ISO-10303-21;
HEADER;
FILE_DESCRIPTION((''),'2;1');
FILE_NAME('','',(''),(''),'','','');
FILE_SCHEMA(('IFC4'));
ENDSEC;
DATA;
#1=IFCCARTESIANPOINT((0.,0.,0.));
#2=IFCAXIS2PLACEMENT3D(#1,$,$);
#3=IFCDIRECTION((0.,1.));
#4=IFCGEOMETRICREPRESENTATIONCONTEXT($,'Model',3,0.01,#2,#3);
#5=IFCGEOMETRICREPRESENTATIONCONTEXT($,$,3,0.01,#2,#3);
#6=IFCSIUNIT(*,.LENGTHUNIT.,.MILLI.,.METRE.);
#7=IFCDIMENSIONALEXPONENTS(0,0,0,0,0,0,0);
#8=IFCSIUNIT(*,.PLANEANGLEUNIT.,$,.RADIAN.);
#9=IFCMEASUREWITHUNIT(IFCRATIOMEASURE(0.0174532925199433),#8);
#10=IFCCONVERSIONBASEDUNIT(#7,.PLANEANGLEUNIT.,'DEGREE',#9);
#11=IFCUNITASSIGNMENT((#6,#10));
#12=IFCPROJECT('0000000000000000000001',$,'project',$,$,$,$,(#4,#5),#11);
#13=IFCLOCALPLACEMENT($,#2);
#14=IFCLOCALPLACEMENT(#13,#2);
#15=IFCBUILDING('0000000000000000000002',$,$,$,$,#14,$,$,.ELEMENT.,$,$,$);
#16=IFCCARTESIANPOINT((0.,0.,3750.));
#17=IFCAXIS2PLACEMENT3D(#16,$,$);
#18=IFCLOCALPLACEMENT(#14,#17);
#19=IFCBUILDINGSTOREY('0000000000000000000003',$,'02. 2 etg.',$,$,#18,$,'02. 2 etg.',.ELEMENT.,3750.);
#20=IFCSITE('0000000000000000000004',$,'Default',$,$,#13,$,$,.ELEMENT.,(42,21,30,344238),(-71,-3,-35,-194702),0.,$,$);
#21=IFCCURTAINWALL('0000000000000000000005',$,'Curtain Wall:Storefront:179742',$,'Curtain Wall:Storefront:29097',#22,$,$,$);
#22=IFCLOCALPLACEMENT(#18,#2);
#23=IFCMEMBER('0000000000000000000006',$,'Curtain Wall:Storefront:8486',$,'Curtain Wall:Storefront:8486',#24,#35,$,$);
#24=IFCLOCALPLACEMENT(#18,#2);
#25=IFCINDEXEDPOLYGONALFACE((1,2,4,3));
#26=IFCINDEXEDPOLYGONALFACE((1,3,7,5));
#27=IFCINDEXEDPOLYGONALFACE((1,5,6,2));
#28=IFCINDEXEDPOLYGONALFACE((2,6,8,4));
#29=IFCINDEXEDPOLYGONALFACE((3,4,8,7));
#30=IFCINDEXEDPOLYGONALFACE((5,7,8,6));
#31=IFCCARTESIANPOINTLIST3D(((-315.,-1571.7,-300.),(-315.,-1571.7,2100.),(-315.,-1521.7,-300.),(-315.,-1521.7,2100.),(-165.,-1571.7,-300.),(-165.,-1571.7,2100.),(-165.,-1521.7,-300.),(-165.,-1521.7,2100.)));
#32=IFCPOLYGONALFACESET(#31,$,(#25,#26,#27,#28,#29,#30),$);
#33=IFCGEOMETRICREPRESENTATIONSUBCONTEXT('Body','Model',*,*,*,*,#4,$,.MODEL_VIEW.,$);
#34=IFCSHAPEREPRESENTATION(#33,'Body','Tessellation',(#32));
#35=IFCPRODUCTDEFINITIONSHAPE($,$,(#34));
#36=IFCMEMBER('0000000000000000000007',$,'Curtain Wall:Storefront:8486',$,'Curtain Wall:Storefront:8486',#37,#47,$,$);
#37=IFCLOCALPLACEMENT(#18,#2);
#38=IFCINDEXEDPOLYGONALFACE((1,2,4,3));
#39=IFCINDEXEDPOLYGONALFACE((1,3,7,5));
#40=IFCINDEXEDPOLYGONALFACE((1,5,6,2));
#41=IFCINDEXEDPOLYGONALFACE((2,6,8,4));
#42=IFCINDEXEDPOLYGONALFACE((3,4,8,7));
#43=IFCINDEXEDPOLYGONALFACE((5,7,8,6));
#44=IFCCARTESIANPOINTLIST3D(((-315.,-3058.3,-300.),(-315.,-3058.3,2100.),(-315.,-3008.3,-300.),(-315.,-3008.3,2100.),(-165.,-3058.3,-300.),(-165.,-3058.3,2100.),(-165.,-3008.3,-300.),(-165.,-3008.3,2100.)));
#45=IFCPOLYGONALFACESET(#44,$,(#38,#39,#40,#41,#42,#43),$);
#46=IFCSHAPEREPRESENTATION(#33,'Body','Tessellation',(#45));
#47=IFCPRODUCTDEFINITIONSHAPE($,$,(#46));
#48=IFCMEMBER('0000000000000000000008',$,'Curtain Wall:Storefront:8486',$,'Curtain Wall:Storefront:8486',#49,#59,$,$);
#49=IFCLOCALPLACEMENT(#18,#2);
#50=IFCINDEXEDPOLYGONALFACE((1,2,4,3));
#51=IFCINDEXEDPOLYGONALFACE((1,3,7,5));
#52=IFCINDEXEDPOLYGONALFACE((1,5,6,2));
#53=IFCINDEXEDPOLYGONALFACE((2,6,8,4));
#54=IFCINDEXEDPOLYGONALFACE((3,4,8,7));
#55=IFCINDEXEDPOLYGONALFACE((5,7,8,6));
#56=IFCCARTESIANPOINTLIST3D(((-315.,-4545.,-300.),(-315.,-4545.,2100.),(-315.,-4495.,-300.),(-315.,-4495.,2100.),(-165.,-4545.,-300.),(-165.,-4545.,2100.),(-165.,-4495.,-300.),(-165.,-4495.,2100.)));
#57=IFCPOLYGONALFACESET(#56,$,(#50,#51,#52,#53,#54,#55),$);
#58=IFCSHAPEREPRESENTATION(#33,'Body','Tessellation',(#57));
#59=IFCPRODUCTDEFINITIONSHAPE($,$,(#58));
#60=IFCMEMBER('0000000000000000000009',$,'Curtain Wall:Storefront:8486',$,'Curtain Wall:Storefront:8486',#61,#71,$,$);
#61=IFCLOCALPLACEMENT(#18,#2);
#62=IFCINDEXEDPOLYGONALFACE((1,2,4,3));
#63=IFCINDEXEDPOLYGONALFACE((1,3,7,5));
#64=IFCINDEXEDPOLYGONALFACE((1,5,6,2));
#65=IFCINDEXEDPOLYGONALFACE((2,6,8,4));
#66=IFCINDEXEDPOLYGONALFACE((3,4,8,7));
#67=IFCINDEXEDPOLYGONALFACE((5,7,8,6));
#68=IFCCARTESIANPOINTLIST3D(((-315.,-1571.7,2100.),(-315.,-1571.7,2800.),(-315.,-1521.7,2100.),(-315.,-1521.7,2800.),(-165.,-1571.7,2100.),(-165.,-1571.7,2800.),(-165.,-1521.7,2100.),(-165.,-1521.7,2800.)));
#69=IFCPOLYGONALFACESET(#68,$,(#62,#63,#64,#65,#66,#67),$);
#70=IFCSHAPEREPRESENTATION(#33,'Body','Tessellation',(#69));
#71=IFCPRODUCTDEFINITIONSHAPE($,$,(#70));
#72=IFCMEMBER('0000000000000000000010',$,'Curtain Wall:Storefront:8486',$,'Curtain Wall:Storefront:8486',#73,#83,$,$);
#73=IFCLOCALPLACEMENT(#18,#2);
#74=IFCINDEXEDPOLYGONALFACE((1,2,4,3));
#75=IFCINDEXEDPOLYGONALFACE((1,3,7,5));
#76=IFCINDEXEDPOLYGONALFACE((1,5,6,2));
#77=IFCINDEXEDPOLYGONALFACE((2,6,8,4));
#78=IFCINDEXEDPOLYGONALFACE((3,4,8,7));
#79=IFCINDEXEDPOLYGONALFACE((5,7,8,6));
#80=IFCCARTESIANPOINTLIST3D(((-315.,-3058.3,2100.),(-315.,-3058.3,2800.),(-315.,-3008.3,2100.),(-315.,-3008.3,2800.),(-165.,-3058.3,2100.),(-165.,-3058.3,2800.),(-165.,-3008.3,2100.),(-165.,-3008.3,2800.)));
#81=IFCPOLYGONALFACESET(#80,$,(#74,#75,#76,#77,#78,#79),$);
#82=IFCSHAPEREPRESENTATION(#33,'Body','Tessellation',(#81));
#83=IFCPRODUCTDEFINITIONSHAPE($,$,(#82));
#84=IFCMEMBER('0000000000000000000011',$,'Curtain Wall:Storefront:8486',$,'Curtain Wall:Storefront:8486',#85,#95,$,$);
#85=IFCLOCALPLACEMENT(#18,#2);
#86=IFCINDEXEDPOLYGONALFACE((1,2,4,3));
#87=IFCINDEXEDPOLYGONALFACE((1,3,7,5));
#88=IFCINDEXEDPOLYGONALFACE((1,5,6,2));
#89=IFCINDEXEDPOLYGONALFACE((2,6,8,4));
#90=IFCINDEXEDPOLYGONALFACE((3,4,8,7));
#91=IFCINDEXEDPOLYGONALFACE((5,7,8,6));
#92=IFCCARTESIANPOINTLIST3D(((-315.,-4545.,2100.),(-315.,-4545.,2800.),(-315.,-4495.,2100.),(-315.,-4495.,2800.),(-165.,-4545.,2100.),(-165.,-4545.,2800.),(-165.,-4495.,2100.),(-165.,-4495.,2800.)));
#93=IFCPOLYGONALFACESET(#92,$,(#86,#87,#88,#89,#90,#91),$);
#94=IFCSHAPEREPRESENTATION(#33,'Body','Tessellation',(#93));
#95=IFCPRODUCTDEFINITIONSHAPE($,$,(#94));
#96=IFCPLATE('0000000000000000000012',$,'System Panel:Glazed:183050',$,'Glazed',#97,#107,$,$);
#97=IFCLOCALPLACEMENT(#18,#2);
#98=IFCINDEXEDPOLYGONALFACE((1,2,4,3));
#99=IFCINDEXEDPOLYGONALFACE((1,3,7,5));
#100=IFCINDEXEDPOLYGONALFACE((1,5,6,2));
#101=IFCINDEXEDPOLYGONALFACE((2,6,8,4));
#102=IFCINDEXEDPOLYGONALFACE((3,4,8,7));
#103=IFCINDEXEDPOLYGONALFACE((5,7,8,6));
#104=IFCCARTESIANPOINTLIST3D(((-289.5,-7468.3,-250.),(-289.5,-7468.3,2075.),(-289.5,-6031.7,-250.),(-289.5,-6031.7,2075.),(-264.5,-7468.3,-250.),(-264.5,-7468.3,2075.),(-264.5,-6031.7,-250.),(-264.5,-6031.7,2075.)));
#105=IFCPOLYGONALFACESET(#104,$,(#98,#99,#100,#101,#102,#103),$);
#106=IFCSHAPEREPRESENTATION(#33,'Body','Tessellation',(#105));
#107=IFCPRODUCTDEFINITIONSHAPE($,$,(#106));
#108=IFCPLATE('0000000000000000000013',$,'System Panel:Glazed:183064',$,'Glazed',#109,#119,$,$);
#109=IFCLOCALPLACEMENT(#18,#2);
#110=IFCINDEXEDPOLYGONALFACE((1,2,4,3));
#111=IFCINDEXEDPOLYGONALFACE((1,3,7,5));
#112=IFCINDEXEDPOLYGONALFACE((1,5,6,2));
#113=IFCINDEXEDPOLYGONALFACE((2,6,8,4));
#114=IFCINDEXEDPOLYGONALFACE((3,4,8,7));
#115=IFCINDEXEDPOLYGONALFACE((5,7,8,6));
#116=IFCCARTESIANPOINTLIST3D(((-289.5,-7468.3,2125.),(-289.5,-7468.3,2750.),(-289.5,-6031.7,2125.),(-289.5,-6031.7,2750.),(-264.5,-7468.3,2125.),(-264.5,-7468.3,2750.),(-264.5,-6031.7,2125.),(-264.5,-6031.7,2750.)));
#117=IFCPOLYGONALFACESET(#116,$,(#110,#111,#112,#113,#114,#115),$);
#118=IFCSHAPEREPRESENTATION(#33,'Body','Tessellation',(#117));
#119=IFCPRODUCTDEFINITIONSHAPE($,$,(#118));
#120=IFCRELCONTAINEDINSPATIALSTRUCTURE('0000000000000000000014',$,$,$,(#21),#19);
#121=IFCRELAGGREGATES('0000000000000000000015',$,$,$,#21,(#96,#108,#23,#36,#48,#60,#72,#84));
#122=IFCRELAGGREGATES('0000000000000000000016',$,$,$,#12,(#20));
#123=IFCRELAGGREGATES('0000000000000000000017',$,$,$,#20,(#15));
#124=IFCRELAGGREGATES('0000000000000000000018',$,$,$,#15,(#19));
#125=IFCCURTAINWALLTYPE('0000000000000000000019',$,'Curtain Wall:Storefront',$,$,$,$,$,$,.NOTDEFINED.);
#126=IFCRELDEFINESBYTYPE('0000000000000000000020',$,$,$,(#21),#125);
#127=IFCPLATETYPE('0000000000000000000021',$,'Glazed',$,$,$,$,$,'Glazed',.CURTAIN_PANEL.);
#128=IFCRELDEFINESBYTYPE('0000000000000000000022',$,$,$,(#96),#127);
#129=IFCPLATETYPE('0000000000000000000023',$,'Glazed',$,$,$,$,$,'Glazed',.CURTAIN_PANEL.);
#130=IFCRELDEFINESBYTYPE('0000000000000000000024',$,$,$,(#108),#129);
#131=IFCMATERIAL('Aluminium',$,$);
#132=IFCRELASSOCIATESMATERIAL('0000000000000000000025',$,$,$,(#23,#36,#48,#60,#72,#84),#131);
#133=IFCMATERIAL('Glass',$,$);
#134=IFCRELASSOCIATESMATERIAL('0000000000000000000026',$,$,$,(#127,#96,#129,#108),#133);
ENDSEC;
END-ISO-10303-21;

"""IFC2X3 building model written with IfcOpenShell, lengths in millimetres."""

from ifc_helpers import new_model, entity, si_unit, converted_unit, direction, frame, frame_2d, origin, origin_2d_with_axis, place, context, subcontext, project, spatial, rectangle, extrude, source, transform, mapped, material, type_object, type_shapes, element, aggregate, save


model = new_model("IFC2X3")

# Units and contexts
model_context = context("Model", 3, precision=0.01, world=origin(), true_north=direction((0.0, 1.0)))
context_of_model = context(None, 3, precision=0.01, world=origin(), true_north=direction((0.0, 1.0)))
body_context = subcontext(model_context, "Body", "Model", "MODEL_VIEW")
ifc_project = project(units=[si_unit("LENGTHUNIT", "METRE", prefix="MILLI"), converted_unit("PLANEANGLEUNIT", "DEGREE", entity("IfcRatioMeasure", 0.0174532925199433), si_unit("PLANEANGLEUNIT", "RADIAN"), dimensions=[0, 0, 0, 0, 0, 0, 0])], contexts=[model_context, context_of_model])

# Site, building, storey
site_placement = place(None, origin())
site = spatial("IfcSite", under=ifc_project, at=site_placement, Name="Default", CompositionType="ELEMENT", RefLatitude=(42, 21, 30, 344238), RefLongitude=(-71, -3, -35, -194702), RefElevation=0.0)
building_placement = place(site_placement, origin())
building = spatial("IfcBuilding", under=site, at=building_placement, CompositionType="ELEMENT")
storey_placement = place(building_placement, frame((0.0, 0.0, 3750.0)))
storey = spatial("IfcBuildingStorey", under=building, at=storey_placement, Name="02. 2 etg.", LongName="02. 2 etg.", CompositionType="ELEMENT", Elevation=3750.0)

# Curtain wall, members, plates
curtain_wall_type = type_object("IfcCurtainWallType", Name="Curtain Wall:Storefront", PredefinedType="NOTDEFINED")
curtain_wall_placement = place(storey_placement, frame((0.0, 0.0, -3750.0)))
curtain_wall = element("IfcCurtainWall", 1, at=curtain_wall_placement, inside=storey, type_object=curtain_wall_type, Name="Curtain Wall:Storefront:179742", ObjectType="Curtain Wall:Storefront:29097")
ifc_material_1 = material(Name="Aluminium")
member_1_placement = place(curtain_wall_placement, frame((-315.0, -1571.7, 3450.0)))
member_1 = element("IfcMember", 2, at=member_1_placement, material=ifc_material_1, Name="Curtain Wall:Storefront:8486", ObjectType="Curtain Wall:Storefront:8486", context=body_context, shape_type="SweptSolid", body=[
    extrude(rectangle(XDim=150.0, YDim=50.0, at=frame_2d((0.0, 0.0), x_axis=(1.0, 0.0))), frame((75.0, 25.0, 0.0)), (0.0, 0.0, 1.0), 2400.0),
])
member_2_placement = place(curtain_wall_placement, frame((-315.0, -3058.3, 3450.0)))
member_2 = element("IfcMember", 3, at=member_2_placement, material=ifc_material_1, Name="Curtain Wall:Storefront:8486", ObjectType="Curtain Wall:Storefront:8486", context=body_context, shape_type="SweptSolid", body=[
    extrude(rectangle(XDim=150.0, YDim=50.0, at=frame_2d((0.0, 0.0), x_axis=(1.0, 0.0))), frame((75.0, 25.0, 0.0)), (0.0, 0.0, 1.0), 2400.0),
])
member_3_placement = place(curtain_wall_placement, frame((-315.0, -4545.0, 3450.0)))
member_3 = element("IfcMember", 4, at=member_3_placement, material=ifc_material_1, Name="Curtain Wall:Storefront:8486", ObjectType="Curtain Wall:Storefront:8486", context=body_context, shape_type="SweptSolid", body=[
    extrude(rectangle(XDim=150.0, YDim=50.0, at=frame_2d((0.0, 0.0), x_axis=(1.0, 0.0))), frame((75.0, 25.0, 0.0)), (0.0, 0.0, 1.0), 2400.0),
])
member_4_placement = place(curtain_wall_placement, frame((-315.0, -1571.7, 5850.0)))
member_4 = element("IfcMember", 5, at=member_4_placement, material=ifc_material_1, Name="Curtain Wall:Storefront:8486", ObjectType="Curtain Wall:Storefront:8486", context=body_context, shape_type="SweptSolid", body=[
    extrude(rectangle(XDim=150.0, YDim=50.0, at=frame_2d((0.0, 0.0), x_axis=(1.0, 0.0))), frame((75.0, 25.0, 0.0)), (0.0, 0.0, 1.0), 700.0),
])
member_5_placement = place(curtain_wall_placement, frame((-315.0, -3058.3, 5850.0)))
member_5 = element("IfcMember", 6, at=member_5_placement, material=ifc_material_1, Name="Curtain Wall:Storefront:8486", ObjectType="Curtain Wall:Storefront:8486", context=body_context, shape_type="SweptSolid", body=[
    extrude(rectangle(XDim=150.0, YDim=50.0, at=frame_2d((0.0, 0.0), x_axis=(1.0, 0.0))), frame((75.0, 25.0, 0.0)), (0.0, 0.0, 1.0), 700.0),
])
member_6_placement = place(curtain_wall_placement, frame((-315.0, -4545.0, 5850.0)))
member_6 = element("IfcMember", 7, at=member_6_placement, material=ifc_material_1, Name="Curtain Wall:Storefront:8486", ObjectType="Curtain Wall:Storefront:8486", context=body_context, shape_type="SweptSolid", body=[
    extrude(rectangle(XDim=150.0, YDim=50.0, at=frame_2d((0.0, 0.0), x_axis=(1.0, 0.0))), frame((75.0, 25.0, 0.0)), (0.0, 0.0, 1.0), 700.0),
])
ifc_material_2 = material(Name="Glass")
plate_type_1 = type_object("IfcPlateType", Name="Glazed", ElementType="Glazed", PredefinedType="CURTAIN_PANEL", material=ifc_material_2)
shared_shape_1 = source(origin(), body_context, "Body", "SweptSolid", [
    extrude(rectangle(XDim=25.0, YDim=1436.7, at=origin_2d_with_axis()), frame((718.3, 12.5, 0.0), z_axis=(0.0, 0.0, 1.0), x_axis=(0.0, 1.0, 0.0)), (0.0, 0.0, 1.0), 2325.0),
])
type_shapes(plate_type_1, [shared_shape_1])
plate_1_placement = place(curtain_wall_placement, frame((-289.5, -6031.7, 3500.0), z_axis=(0.0, 0.0, 1.0), x_axis=(0.0, -1.0, 0.0)))
plate_1 = element("IfcPlate", 8, at=plate_1_placement, type_object=plate_type_1, material=ifc_material_2, Name="System Panel:Glazed:183050", ObjectType="Glazed", context=body_context, shape_type="MappedRepresentation", body=[
    mapped(shared_shape_1, transform((0.0, 0.0, 0.0), scale=1.0)),
])
plate_type_2 = type_object("IfcPlateType", Name="Glazed", ElementType="Glazed", PredefinedType="CURTAIN_PANEL", material=ifc_material_2)
shared_shape_2 = source(origin(), body_context, "Body", "SweptSolid", [
    extrude(rectangle(XDim=25.0, YDim=1436.7, at=origin_2d_with_axis()), frame((718.3, 12.5, 0.0), z_axis=(0.0, 0.0, 1.0), x_axis=(0.0, 1.0, 0.0)), (0.0, 0.0, 1.0), 625.0),
])
type_shapes(plate_type_2, [shared_shape_2])
plate_2_placement = place(curtain_wall_placement, frame((-289.5, -6031.7, 5875.0), z_axis=(0.0, 0.0, 1.0), x_axis=(0.0, -1.0, 0.0)))
plate_2 = element("IfcPlate", 9, at=plate_2_placement, type_object=plate_type_2, material=ifc_material_2, Name="System Panel:Glazed:183064", ObjectType="Glazed", context=body_context, shape_type="MappedRepresentation", body=[
    mapped(shared_shape_2, transform((0.0, 0.0, 0.0), scale=1.0)),
])
aggregate(curtain_wall, [plate_1, plate_2, member_1, member_2, member_3, member_4, member_5, member_6])

save(model, "model.ifc")
